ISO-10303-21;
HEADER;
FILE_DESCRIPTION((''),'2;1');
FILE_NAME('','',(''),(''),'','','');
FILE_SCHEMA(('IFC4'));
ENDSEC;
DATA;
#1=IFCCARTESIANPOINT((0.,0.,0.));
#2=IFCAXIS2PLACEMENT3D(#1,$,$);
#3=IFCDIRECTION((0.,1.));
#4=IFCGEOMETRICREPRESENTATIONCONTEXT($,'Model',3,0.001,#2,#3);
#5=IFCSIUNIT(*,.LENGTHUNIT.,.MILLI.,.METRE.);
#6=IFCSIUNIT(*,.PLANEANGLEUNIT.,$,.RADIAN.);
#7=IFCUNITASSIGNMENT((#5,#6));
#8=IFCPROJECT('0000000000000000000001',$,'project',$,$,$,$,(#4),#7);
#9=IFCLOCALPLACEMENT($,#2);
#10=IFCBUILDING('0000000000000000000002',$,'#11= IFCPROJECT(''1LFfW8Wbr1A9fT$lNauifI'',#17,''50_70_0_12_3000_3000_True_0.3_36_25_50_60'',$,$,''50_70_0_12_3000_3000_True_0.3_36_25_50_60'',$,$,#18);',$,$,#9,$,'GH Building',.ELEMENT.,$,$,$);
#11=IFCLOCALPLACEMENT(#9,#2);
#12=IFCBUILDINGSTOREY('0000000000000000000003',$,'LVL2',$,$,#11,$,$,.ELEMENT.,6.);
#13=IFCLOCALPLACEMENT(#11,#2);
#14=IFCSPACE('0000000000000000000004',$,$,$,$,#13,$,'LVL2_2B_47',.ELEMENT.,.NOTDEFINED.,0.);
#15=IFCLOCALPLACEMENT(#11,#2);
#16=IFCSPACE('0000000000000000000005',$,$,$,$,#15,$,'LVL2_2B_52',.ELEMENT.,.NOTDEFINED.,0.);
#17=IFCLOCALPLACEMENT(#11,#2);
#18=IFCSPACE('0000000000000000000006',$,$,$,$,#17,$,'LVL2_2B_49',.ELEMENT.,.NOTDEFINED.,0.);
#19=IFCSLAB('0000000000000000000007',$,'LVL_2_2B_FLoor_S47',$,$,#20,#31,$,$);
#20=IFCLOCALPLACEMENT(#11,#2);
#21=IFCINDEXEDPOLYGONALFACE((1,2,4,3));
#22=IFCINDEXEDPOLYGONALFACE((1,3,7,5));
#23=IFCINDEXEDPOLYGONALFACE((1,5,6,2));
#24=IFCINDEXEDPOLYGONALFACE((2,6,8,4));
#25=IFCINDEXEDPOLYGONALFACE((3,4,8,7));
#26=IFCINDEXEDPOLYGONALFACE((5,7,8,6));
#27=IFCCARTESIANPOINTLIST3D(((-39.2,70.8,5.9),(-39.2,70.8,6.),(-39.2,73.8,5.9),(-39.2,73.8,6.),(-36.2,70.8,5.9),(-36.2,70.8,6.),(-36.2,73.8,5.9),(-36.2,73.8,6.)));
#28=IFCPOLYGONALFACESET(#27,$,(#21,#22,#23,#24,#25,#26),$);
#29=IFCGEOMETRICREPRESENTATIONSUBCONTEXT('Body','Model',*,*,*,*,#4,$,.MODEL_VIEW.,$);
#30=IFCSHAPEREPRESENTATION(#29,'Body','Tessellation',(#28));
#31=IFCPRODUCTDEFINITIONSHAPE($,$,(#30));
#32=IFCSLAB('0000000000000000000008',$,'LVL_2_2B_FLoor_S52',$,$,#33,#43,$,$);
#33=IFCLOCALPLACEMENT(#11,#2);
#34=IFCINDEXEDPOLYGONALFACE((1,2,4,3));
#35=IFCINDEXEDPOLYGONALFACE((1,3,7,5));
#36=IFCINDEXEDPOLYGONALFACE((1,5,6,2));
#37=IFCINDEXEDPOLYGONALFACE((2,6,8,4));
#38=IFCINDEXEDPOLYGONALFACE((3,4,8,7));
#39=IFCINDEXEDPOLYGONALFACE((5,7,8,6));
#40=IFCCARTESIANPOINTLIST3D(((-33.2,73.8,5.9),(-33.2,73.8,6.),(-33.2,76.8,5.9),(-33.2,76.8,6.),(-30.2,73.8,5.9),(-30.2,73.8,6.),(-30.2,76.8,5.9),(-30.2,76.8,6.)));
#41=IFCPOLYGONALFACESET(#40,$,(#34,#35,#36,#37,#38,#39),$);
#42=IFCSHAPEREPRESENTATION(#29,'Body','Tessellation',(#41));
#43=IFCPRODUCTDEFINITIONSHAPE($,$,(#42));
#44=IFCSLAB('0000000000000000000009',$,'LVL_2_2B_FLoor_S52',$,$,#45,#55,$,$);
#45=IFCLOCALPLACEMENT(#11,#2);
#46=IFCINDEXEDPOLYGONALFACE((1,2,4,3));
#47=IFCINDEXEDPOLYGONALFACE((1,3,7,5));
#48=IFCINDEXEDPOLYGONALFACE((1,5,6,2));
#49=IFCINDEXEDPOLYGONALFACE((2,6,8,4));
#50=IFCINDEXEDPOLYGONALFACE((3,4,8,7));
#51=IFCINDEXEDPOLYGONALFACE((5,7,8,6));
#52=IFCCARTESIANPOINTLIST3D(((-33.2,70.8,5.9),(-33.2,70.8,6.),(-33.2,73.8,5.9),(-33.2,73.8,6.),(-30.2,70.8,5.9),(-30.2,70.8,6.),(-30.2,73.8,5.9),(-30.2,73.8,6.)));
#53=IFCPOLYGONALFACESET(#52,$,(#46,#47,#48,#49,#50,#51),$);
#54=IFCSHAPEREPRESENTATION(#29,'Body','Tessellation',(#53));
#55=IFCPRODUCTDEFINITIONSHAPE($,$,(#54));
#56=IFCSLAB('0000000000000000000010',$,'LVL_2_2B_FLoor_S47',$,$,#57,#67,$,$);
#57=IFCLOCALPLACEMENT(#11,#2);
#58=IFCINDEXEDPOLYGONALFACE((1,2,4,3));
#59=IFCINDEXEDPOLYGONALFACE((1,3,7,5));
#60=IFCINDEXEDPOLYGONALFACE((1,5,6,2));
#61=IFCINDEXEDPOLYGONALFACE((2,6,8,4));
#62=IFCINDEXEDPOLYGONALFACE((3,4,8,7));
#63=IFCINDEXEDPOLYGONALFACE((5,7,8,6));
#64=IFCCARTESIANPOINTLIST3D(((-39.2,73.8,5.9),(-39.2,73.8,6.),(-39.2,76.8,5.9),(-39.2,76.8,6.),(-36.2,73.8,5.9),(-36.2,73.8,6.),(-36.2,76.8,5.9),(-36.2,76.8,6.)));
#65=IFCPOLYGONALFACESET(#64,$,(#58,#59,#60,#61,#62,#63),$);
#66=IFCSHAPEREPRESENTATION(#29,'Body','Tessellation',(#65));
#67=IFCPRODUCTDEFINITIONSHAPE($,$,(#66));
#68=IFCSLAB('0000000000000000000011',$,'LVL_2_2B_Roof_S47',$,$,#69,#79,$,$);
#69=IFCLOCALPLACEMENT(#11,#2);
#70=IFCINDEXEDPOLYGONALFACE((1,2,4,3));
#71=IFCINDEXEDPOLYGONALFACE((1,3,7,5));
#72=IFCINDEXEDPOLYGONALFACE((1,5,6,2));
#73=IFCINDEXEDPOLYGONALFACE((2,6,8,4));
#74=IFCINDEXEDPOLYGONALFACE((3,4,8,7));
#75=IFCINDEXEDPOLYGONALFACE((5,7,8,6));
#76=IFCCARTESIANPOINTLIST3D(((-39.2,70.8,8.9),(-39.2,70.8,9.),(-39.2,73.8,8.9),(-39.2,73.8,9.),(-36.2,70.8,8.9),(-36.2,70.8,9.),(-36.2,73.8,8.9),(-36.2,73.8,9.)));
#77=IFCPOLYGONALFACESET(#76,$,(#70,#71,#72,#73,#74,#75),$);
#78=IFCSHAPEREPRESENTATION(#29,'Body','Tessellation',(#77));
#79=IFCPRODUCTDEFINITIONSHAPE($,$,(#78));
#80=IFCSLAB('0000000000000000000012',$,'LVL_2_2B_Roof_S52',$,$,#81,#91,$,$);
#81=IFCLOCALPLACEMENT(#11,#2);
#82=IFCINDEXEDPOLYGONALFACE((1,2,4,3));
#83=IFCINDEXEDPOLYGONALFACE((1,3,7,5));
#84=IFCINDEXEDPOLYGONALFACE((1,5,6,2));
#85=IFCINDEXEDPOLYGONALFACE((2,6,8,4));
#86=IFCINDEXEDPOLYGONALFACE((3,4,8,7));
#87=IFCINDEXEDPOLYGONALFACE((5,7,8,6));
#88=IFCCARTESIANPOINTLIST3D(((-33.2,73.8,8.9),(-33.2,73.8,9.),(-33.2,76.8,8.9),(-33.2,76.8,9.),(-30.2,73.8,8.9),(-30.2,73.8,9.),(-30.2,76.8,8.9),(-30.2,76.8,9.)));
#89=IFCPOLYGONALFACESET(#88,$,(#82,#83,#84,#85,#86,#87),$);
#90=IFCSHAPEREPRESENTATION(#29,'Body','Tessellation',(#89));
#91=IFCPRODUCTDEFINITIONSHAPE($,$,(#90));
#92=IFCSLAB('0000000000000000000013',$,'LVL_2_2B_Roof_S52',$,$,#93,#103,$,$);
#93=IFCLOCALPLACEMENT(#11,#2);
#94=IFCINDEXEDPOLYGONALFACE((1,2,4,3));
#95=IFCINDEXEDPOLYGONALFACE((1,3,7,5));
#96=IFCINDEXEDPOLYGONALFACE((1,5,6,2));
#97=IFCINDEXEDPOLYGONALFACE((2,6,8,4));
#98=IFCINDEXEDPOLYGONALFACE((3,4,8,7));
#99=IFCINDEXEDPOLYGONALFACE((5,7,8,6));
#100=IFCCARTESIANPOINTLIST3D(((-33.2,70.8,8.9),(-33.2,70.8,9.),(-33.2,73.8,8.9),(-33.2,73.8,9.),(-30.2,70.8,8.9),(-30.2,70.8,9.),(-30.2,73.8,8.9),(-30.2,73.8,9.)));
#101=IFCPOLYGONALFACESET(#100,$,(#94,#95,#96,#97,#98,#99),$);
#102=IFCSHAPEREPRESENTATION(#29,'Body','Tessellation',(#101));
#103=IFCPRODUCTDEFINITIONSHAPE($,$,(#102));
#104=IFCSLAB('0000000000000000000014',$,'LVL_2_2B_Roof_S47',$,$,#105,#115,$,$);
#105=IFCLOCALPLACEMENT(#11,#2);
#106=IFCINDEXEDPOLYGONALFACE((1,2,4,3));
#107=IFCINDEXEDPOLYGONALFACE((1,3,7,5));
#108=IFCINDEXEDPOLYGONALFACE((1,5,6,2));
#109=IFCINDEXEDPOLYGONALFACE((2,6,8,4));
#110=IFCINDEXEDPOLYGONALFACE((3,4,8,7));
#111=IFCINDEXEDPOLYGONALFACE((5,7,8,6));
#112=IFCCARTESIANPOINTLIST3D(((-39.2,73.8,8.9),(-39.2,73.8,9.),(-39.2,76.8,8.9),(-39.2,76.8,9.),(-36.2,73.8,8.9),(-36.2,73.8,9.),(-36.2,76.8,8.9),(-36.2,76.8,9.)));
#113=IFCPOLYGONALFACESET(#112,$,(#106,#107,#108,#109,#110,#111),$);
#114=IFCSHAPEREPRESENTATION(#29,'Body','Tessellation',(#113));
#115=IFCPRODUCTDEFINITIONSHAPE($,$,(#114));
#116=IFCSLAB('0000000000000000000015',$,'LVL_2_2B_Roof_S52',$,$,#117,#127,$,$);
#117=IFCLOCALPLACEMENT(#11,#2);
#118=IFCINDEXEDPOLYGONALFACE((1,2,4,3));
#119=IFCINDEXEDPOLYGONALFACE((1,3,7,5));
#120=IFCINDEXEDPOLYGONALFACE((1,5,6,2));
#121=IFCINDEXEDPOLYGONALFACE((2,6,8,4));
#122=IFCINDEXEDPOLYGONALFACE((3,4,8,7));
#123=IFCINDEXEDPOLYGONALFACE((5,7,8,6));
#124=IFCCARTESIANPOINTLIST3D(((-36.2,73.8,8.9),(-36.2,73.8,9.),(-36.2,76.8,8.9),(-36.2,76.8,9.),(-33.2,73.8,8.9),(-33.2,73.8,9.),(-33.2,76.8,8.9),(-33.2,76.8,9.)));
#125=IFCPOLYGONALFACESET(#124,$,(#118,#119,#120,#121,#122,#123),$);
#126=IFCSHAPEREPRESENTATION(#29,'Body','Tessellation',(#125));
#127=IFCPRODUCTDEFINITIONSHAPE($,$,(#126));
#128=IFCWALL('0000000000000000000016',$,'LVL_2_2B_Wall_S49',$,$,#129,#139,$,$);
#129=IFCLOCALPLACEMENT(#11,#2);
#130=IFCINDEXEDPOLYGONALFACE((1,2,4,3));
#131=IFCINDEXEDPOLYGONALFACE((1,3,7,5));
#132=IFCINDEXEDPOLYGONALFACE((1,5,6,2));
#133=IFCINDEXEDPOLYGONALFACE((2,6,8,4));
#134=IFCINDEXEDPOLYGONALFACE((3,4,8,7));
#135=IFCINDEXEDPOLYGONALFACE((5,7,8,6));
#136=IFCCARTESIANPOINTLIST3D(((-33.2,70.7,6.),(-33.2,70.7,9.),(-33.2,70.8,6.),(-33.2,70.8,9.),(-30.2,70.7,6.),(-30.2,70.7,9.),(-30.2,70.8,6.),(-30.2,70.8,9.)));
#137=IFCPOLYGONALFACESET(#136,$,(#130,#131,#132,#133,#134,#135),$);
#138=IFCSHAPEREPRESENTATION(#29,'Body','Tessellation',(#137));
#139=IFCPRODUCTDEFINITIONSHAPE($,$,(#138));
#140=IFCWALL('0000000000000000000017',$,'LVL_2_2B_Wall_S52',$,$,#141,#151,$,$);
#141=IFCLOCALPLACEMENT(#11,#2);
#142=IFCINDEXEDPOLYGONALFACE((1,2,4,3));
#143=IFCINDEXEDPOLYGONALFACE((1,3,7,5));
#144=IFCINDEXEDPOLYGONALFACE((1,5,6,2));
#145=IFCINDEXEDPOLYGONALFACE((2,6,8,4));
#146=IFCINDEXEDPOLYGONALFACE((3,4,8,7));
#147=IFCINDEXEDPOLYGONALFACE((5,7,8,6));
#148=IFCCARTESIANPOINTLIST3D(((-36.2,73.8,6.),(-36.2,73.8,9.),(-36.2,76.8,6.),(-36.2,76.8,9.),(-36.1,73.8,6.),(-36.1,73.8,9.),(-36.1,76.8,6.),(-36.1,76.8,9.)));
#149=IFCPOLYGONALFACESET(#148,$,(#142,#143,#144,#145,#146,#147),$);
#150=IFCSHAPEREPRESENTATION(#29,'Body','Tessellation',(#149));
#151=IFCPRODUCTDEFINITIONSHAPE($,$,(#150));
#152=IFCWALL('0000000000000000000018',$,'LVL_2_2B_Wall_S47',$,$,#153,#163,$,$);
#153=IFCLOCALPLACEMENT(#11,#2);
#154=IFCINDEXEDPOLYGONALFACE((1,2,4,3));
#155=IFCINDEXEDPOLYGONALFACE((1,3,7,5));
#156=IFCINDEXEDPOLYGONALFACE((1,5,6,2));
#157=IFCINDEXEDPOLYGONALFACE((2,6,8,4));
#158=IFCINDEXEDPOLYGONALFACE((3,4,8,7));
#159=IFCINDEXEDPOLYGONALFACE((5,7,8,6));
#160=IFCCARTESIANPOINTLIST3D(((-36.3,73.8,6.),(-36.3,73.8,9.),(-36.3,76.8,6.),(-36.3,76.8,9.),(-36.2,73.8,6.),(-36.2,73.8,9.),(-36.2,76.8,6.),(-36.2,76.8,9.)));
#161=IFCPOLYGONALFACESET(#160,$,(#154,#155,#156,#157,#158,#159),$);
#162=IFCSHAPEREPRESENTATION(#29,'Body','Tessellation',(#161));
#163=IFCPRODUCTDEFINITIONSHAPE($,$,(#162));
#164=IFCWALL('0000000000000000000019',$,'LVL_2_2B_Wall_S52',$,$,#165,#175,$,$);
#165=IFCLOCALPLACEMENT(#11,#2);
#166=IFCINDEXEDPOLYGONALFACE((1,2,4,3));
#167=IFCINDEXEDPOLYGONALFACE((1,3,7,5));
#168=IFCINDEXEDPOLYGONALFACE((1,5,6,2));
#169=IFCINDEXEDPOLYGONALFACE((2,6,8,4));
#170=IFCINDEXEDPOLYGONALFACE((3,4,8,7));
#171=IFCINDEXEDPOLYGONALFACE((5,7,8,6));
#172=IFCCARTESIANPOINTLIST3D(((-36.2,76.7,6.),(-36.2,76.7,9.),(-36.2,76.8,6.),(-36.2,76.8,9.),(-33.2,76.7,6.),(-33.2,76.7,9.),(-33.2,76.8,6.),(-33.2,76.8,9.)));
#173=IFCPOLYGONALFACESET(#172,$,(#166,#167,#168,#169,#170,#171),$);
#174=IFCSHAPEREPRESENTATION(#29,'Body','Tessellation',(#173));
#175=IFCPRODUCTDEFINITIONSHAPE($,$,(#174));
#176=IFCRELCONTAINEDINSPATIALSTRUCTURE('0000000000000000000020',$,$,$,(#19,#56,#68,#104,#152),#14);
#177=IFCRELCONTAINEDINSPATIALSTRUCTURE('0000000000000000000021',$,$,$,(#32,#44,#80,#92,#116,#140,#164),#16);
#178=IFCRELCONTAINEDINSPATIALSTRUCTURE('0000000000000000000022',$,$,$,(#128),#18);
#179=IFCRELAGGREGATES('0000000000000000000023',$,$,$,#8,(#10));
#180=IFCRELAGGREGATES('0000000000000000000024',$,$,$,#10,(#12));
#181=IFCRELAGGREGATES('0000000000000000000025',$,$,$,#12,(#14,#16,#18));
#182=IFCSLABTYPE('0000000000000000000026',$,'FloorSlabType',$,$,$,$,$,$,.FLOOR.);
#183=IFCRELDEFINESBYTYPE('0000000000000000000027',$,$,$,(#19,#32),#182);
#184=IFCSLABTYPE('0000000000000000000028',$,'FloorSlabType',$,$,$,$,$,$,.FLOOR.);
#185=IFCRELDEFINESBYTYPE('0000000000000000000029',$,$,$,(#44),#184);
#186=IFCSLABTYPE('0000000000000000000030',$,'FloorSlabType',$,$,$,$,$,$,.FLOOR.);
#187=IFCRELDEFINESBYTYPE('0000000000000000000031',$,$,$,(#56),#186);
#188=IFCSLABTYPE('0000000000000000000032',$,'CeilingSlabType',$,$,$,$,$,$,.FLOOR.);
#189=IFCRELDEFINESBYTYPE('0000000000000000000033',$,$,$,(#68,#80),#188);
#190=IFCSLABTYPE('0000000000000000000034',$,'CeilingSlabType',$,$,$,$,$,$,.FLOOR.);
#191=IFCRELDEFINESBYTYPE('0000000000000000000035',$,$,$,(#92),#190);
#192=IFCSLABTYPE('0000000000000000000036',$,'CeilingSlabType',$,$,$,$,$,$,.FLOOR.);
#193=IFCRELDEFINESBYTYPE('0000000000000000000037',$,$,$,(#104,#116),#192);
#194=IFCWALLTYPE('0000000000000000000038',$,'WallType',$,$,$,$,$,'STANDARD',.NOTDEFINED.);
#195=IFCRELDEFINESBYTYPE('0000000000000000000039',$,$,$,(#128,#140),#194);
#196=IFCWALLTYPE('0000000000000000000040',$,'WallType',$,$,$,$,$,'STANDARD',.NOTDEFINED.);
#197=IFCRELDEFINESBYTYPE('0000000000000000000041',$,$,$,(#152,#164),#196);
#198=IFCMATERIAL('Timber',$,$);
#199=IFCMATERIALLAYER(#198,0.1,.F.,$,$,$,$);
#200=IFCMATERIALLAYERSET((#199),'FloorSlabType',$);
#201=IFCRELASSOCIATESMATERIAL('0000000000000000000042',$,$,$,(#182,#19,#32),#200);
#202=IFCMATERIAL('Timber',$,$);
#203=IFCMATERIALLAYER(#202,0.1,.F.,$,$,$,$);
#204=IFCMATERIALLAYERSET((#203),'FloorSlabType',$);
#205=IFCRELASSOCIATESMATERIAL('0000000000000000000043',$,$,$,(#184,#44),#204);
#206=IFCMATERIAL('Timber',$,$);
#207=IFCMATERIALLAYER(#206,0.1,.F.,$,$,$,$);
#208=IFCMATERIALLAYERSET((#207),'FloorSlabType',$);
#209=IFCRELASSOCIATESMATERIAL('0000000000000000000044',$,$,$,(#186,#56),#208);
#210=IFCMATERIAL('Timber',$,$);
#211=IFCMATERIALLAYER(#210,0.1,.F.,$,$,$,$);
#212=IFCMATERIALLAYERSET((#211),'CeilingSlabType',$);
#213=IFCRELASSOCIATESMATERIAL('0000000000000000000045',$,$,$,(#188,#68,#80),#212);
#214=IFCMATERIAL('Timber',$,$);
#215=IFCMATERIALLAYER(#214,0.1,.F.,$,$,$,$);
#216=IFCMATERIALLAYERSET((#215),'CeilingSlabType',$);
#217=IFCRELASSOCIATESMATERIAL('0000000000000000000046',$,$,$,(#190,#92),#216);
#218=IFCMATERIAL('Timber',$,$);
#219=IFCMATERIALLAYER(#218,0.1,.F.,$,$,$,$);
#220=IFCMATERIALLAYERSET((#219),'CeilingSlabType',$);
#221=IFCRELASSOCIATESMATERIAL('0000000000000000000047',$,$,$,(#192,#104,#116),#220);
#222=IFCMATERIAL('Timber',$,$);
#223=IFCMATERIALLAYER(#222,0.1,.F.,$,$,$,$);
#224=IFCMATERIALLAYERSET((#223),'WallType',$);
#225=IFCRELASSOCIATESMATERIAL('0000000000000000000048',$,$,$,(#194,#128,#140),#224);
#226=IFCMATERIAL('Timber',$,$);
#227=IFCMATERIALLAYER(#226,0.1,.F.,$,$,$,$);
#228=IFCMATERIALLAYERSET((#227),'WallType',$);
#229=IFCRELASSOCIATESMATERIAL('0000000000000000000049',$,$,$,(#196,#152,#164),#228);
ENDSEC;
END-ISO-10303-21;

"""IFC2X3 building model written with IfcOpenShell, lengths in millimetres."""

from ifc_helpers import new_model, si_unit, direction, frame, frame_2d, origin, place, context, subcontext, project, spatial, rectangle, extrude, material, layer, layer_set, layer_usage, type_object, element, save


model = new_model("IFC2X3")

# Units and contexts
model_context = context("Model", 3, precision=0.001, world=origin(), true_north=direction((0.0, 1.0)))
body_context = subcontext(model_context, "Body", "Model", "MODEL_VIEW")
ifc_project = project(units=[si_unit("LENGTHUNIT", "METRE", prefix="MILLI"), si_unit("PLANEANGLEUNIT", "RADIAN")], contexts=[model_context])

# Building, storey, space
building_placement = place(None, origin())
building = spatial("IfcBuilding", under=ifc_project, at=building_placement, Name="#11= IFCPROJECT('1LFfW8Wbr1A9fT$lNauifI',#17,'50_70_0_12_3000_3000_True_0.3_36_25_50_60',$,$,'50_70_0_12_3000_3000_True_0.3_36_25_50_60',$,$,#18);", LongName="GH Building", CompositionType="ELEMENT")
storey_placement = place(building_placement, origin())
storey = spatial("IfcBuildingStorey", under=building, at=storey_placement, Name="LVL2", CompositionType="ELEMENT", Elevation=6.0)
space_1_placement = place(storey_placement, origin())
space_1 = spatial("IfcSpace", under=storey, at=space_1_placement, LongName="LVL2_2B_47", CompositionType="ELEMENT", InteriorOrExteriorSpace="NOTDEFINED", ElevationWithFlooring=0.0)

# Slab
ifc_material_1 = material(Name="Timber")
ifc_layer_1 = layer(ifc_material_1, 0.1, ventilated=False)
ifc_layer_set_1 = layer_set([ifc_layer_1], Name="FloorSlabType")
ifc_layer_usage_1 = layer_usage(ifc_layer_set_1, "AXIS3", "NEGATIVE", -0.1)
slab_type_1 = type_object("IfcSlabType", Name="FloorSlabType", PredefinedType="FLOOR", material=ifc_layer_set_1)
slab_1_placement = place(space_1_placement, frame((-36.2, 73.8, 5.9), z_axis=(0.0, 0.0, 1.0), x_axis=(-1.0, 0.0, 0.0)))
element("IfcSlab", 1, at=slab_1_placement, inside=space_1, type_object=slab_type_1, material=ifc_layer_usage_1, Name="LVL_2_2B_FLoor_S47", context=body_context, shape_type="SweptSolid", body=[
    extrude(rectangle(XDim=3.0, YDim=3.0, at=frame_2d((1.5, 1.5))), origin(), (0.0, 0.0, 1.0), 0.1),
])

# Shared definitions
space_2_placement = place(storey_placement, origin())
space_2 = spatial("IfcSpace", under=storey, at=space_2_placement, LongName="LVL2_2B_52", CompositionType="ELEMENT", InteriorOrExteriorSpace="NOTDEFINED", ElevationWithFlooring=0.0)

# Slabs
ifc_layer_usage_2 = layer_usage(ifc_layer_set_1, "AXIS3", "NEGATIVE", -0.1)
slab_2_placement = place(space_2_placement, frame((-33.2, 76.8, 5.9), z_axis=(0.0, 0.0, 1.0), x_axis=(0.0, -1.0, 0.0)))
element("IfcSlab", 2, at=slab_2_placement, inside=space_2, type_object=slab_type_1, material=ifc_layer_usage_2, Name="LVL_2_2B_FLoor_S52", context=body_context, shape_type="SweptSolid", body=[
    extrude(rectangle(XDim=3.0, YDim=3.0, at=frame_2d((1.5, 1.5))), origin(), (0.0, 0.0, 1.0), 0.1),
])
ifc_material_2 = material(Name="Timber")
ifc_layer_2 = layer(ifc_material_2, 0.1, ventilated=False)
ifc_layer_set_2 = layer_set([ifc_layer_2], Name="FloorSlabType")
ifc_layer_usage_3 = layer_usage(ifc_layer_set_2, "AXIS3", "NEGATIVE", -0.1)
slab_type_2 = type_object("IfcSlabType", Name="FloorSlabType", PredefinedType="FLOOR", material=ifc_layer_set_2)
slab_3_placement = place(space_2_placement, frame((-33.2, 73.8, 5.9), z_axis=(0.0, 0.0, 1.0), x_axis=(0.0, -1.0, 0.0)))
element("IfcSlab", 3, at=slab_3_placement, inside=space_2, type_object=slab_type_2, material=ifc_layer_usage_3, Name="LVL_2_2B_FLoor_S52", context=body_context, shape_type="SweptSolid", body=[
    extrude(rectangle(XDim=3.0, YDim=3.0, at=frame_2d((1.5, 1.5))), origin(), (0.0, 0.0, 1.0), 0.1),
])
ifc_material_3 = material(Name="Timber")
ifc_layer_3 = layer(ifc_material_3, 0.1, ventilated=False)
ifc_layer_set_3 = layer_set([ifc_layer_3], Name="FloorSlabType")
ifc_layer_usage_4 = layer_usage(ifc_layer_set_3, "AXIS3", "NEGATIVE", -0.1)
slab_type_3 = type_object("IfcSlabType", Name="FloorSlabType", PredefinedType="FLOOR", material=ifc_layer_set_3)
slab_4_placement = place(space_1_placement, frame((-36.2, 76.8, 5.9), z_axis=(0.0, 0.0, 1.0), x_axis=(-1.0, 0.0, 0.0)))
element("IfcSlab", 4, at=slab_4_placement, inside=space_1, type_object=slab_type_3, material=ifc_layer_usage_4, Name="LVL_2_2B_FLoor_S47", context=body_context, shape_type="SweptSolid", body=[
    extrude(rectangle(XDim=3.0, YDim=3.0, at=frame_2d((1.5, 1.5))), origin(), (0.0, 0.0, 1.0), 0.1),
])
ifc_material_4 = material(Name="Timber")
ifc_layer_4 = layer(ifc_material_4, 0.1, ventilated=False)
ifc_layer_set_4 = layer_set([ifc_layer_4], Name="CeilingSlabType")
ifc_layer_usage_5 = layer_usage(ifc_layer_set_4, "AXIS3", "NEGATIVE", -0.1)
slab_type_4 = type_object("IfcSlabType", Name="CeilingSlabType", PredefinedType="FLOOR", material=ifc_layer_set_4)
slab_5_placement = place(space_1_placement, frame((-36.2, 73.8, 8.9), z_axis=(0.0, 0.0, 1.0), x_axis=(-1.0, 0.0, 0.0)))
element("IfcSlab", 5, at=slab_5_placement, inside=space_1, type_object=slab_type_4, material=ifc_layer_usage_5, Name="LVL_2_2B_Roof_S47", context=body_context, shape_type="SweptSolid", body=[
    extrude(rectangle(XDim=3.0, YDim=3.0, at=frame_2d((1.5, 1.5))), origin(), (0.0, 0.0, 1.0), 0.1),
])
ifc_layer_usage_6 = layer_usage(ifc_layer_set_4, "AXIS3", "NEGATIVE", -0.1)
slab_6_placement = place(space_2_placement, frame((-33.2, 76.8, 8.9), z_axis=(0.0, 0.0, 1.0), x_axis=(0.0, -1.0, 0.0)))
element("IfcSlab", 6, at=slab_6_placement, inside=space_2, type_object=slab_type_4, material=ifc_layer_usage_6, Name="LVL_2_2B_Roof_S52", context=body_context, shape_type="SweptSolid", body=[
    extrude(rectangle(XDim=3.0, YDim=3.0, at=frame_2d((1.5, 1.5))), origin(), (0.0, 0.0, 1.0), 0.1),
])
ifc_material_5 = material(Name="Timber")
ifc_layer_5 = layer(ifc_material_5, 0.1, ventilated=False)
ifc_layer_set_5 = layer_set([ifc_layer_5], Name="CeilingSlabType")
ifc_layer_usage_7 = layer_usage(ifc_layer_set_5, "AXIS3", "NEGATIVE", -0.1)
slab_type_5 = type_object("IfcSlabType", Name="CeilingSlabType", PredefinedType="FLOOR", material=ifc_layer_set_5)
slab_7_placement = place(space_2_placement, frame((-33.2, 73.8, 8.9), z_axis=(0.0, 0.0, 1.0), x_axis=(0.0, -1.0, 0.0)))
element("IfcSlab", 7, at=slab_7_placement, inside=space_2, type_object=slab_type_5, material=ifc_layer_usage_7, Name="LVL_2_2B_Roof_S52", context=body_context, shape_type="SweptSolid", body=[
    extrude(rectangle(XDim=3.0, YDim=3.0, at=frame_2d((1.5, 1.5))), origin(), (0.0, 0.0, 1.0), 0.1),
])
ifc_material_6 = material(Name="Timber")
ifc_layer_6 = layer(ifc_material_6, 0.1, ventilated=False)
ifc_layer_set_6 = layer_set([ifc_layer_6], Name="CeilingSlabType")
ifc_layer_usage_8 = layer_usage(ifc_layer_set_6, "AXIS3", "NEGATIVE", -0.1)
slab_type_6 = type_object("IfcSlabType", Name="CeilingSlabType", PredefinedType="FLOOR", material=ifc_layer_set_6)
slab_8_placement = place(space_1_placement, frame((-36.2, 76.8, 8.9), z_axis=(0.0, 0.0, 1.0), x_axis=(-1.0, 0.0, 0.0)))
element("IfcSlab", 8, at=slab_8_placement, inside=space_1, type_object=slab_type_6, material=ifc_layer_usage_8, Name="LVL_2_2B_Roof_S47", context=body_context, shape_type="SweptSolid", body=[
    extrude(rectangle(XDim=3.0, YDim=3.0, at=frame_2d((1.5, 1.5))), origin(), (0.0, 0.0, 1.0), 0.1),
])
ifc_layer_usage_9 = layer_usage(ifc_layer_set_6, "AXIS3", "NEGATIVE", -0.1)
slab_9_placement = place(space_2_placement, frame((-36.2, 76.8, 8.9), z_axis=(0.0, 0.0, 1.0), x_axis=(0.0, -1.0, 0.0)))
element("IfcSlab", 9, at=slab_9_placement, inside=space_2, type_object=slab_type_6, material=ifc_layer_usage_9, Name="LVL_2_2B_Roof_S52", context=body_context, shape_type="SweptSolid", body=[
    extrude(rectangle(XDim=3.0, YDim=3.0, at=frame_2d((1.5, 1.5))), origin(), (0.0, 0.0, 1.0), 0.1),
])

# Shared definitions
space_3_placement = place(storey_placement, origin())
space_3 = spatial("IfcSpace", under=storey, at=space_3_placement, LongName="LVL2_2B_49", CompositionType="ELEMENT", InteriorOrExteriorSpace="NOTDEFINED", ElevationWithFlooring=0.0)

# Walls
ifc_material_7 = material(Name="Timber")
ifc_layer_7 = layer(ifc_material_7, 0.1, ventilated=False)
ifc_layer_set_7 = layer_set([ifc_layer_7], Name="WallType")
ifc_layer_usage_10 = layer_usage(ifc_layer_set_7, "AXIS2", "NEGATIVE", 0.0)
wall_type_1 = type_object("IfcWallType", Name="WallType", ElementType="STANDARD", PredefinedType="NOTDEFINED", material=ifc_layer_set_7)
wall_1_placement = place(space_3_placement, frame((-33.2, 70.8, 6.0)))
element("IfcWall", 10, at=wall_1_placement, inside=space_3, type_object=wall_type_1, material=ifc_layer_usage_10, Name="LVL_2_2B_Wall_S49", context=body_context, shape_type="SweptSolid", body=[
    extrude(rectangle(XDim=3.0, YDim=0.1, at=frame_2d((1.5, -0.1))), origin(), (0.0, 0.0, 1.0), 3.0),
])
ifc_layer_usage_11 = layer_usage(ifc_layer_set_7, "AXIS2", "NEGATIVE", 0.0)
wall_2_placement = place(space_2_placement, frame((-36.2, 73.8, 6.0), z_axis=(0.0, 0.0, 1.0), x_axis=(0.0, 1.0, 0.0)))
element("IfcWall", 11, at=wall_2_placement, inside=space_2, type_object=wall_type_1, material=ifc_layer_usage_11, Name="LVL_2_2B_Wall_S52", context=body_context, shape_type="SweptSolid", body=[
    extrude(rectangle(XDim=3.0, YDim=0.1, at=frame_2d((1.5, -0.1))), origin(), (0.0, 0.0, 1.0), 3.0),
])
ifc_material_8 = material(Name="Timber")
ifc_layer_8 = layer(ifc_material_8, 0.1, ventilated=False)
ifc_layer_set_8 = layer_set([ifc_layer_8], Name="WallType")
ifc_layer_usage_12 = layer_usage(ifc_layer_set_8, "AXIS2", "NEGATIVE", 0.0)
wall_type_2 = type_object("IfcWallType", Name="WallType", ElementType="STANDARD", PredefinedType="NOTDEFINED", material=ifc_layer_set_8)
wall_3_placement = place(space_1_placement, frame((-36.2, 76.8, 6.0), z_axis=(0.0, 0.0, 1.0), x_axis=(0.0, -1.0, 0.0)))
element("IfcWall", 12, at=wall_3_placement, inside=space_1, type_object=wall_type_2, material=ifc_layer_usage_12, Name="LVL_2_2B_Wall_S47", context=body_context, shape_type="SweptSolid", body=[
    extrude(rectangle(XDim=3.0, YDim=0.1, at=frame_2d((1.5, -0.1))), origin(), (0.0, 0.0, 1.0), 3.0),
])
ifc_layer_usage_13 = layer_usage(ifc_layer_set_8, "AXIS2", "NEGATIVE", 0.0)
wall_4_placement = place(space_2_placement, frame((-36.2, 76.8, 6.0)))
element("IfcWall", 13, at=wall_4_placement, inside=space_2, type_object=wall_type_2, material=ifc_layer_usage_13, Name="LVL_2_2B_Wall_S52", context=body_context, shape_type="SweptSolid", body=[
    extrude(rectangle(XDim=3.0, YDim=0.1, at=frame_2d((1.5, -0.1))), origin(), (0.0, 0.0, 1.0), 3.0),
])

save(model, "model.ifc")
